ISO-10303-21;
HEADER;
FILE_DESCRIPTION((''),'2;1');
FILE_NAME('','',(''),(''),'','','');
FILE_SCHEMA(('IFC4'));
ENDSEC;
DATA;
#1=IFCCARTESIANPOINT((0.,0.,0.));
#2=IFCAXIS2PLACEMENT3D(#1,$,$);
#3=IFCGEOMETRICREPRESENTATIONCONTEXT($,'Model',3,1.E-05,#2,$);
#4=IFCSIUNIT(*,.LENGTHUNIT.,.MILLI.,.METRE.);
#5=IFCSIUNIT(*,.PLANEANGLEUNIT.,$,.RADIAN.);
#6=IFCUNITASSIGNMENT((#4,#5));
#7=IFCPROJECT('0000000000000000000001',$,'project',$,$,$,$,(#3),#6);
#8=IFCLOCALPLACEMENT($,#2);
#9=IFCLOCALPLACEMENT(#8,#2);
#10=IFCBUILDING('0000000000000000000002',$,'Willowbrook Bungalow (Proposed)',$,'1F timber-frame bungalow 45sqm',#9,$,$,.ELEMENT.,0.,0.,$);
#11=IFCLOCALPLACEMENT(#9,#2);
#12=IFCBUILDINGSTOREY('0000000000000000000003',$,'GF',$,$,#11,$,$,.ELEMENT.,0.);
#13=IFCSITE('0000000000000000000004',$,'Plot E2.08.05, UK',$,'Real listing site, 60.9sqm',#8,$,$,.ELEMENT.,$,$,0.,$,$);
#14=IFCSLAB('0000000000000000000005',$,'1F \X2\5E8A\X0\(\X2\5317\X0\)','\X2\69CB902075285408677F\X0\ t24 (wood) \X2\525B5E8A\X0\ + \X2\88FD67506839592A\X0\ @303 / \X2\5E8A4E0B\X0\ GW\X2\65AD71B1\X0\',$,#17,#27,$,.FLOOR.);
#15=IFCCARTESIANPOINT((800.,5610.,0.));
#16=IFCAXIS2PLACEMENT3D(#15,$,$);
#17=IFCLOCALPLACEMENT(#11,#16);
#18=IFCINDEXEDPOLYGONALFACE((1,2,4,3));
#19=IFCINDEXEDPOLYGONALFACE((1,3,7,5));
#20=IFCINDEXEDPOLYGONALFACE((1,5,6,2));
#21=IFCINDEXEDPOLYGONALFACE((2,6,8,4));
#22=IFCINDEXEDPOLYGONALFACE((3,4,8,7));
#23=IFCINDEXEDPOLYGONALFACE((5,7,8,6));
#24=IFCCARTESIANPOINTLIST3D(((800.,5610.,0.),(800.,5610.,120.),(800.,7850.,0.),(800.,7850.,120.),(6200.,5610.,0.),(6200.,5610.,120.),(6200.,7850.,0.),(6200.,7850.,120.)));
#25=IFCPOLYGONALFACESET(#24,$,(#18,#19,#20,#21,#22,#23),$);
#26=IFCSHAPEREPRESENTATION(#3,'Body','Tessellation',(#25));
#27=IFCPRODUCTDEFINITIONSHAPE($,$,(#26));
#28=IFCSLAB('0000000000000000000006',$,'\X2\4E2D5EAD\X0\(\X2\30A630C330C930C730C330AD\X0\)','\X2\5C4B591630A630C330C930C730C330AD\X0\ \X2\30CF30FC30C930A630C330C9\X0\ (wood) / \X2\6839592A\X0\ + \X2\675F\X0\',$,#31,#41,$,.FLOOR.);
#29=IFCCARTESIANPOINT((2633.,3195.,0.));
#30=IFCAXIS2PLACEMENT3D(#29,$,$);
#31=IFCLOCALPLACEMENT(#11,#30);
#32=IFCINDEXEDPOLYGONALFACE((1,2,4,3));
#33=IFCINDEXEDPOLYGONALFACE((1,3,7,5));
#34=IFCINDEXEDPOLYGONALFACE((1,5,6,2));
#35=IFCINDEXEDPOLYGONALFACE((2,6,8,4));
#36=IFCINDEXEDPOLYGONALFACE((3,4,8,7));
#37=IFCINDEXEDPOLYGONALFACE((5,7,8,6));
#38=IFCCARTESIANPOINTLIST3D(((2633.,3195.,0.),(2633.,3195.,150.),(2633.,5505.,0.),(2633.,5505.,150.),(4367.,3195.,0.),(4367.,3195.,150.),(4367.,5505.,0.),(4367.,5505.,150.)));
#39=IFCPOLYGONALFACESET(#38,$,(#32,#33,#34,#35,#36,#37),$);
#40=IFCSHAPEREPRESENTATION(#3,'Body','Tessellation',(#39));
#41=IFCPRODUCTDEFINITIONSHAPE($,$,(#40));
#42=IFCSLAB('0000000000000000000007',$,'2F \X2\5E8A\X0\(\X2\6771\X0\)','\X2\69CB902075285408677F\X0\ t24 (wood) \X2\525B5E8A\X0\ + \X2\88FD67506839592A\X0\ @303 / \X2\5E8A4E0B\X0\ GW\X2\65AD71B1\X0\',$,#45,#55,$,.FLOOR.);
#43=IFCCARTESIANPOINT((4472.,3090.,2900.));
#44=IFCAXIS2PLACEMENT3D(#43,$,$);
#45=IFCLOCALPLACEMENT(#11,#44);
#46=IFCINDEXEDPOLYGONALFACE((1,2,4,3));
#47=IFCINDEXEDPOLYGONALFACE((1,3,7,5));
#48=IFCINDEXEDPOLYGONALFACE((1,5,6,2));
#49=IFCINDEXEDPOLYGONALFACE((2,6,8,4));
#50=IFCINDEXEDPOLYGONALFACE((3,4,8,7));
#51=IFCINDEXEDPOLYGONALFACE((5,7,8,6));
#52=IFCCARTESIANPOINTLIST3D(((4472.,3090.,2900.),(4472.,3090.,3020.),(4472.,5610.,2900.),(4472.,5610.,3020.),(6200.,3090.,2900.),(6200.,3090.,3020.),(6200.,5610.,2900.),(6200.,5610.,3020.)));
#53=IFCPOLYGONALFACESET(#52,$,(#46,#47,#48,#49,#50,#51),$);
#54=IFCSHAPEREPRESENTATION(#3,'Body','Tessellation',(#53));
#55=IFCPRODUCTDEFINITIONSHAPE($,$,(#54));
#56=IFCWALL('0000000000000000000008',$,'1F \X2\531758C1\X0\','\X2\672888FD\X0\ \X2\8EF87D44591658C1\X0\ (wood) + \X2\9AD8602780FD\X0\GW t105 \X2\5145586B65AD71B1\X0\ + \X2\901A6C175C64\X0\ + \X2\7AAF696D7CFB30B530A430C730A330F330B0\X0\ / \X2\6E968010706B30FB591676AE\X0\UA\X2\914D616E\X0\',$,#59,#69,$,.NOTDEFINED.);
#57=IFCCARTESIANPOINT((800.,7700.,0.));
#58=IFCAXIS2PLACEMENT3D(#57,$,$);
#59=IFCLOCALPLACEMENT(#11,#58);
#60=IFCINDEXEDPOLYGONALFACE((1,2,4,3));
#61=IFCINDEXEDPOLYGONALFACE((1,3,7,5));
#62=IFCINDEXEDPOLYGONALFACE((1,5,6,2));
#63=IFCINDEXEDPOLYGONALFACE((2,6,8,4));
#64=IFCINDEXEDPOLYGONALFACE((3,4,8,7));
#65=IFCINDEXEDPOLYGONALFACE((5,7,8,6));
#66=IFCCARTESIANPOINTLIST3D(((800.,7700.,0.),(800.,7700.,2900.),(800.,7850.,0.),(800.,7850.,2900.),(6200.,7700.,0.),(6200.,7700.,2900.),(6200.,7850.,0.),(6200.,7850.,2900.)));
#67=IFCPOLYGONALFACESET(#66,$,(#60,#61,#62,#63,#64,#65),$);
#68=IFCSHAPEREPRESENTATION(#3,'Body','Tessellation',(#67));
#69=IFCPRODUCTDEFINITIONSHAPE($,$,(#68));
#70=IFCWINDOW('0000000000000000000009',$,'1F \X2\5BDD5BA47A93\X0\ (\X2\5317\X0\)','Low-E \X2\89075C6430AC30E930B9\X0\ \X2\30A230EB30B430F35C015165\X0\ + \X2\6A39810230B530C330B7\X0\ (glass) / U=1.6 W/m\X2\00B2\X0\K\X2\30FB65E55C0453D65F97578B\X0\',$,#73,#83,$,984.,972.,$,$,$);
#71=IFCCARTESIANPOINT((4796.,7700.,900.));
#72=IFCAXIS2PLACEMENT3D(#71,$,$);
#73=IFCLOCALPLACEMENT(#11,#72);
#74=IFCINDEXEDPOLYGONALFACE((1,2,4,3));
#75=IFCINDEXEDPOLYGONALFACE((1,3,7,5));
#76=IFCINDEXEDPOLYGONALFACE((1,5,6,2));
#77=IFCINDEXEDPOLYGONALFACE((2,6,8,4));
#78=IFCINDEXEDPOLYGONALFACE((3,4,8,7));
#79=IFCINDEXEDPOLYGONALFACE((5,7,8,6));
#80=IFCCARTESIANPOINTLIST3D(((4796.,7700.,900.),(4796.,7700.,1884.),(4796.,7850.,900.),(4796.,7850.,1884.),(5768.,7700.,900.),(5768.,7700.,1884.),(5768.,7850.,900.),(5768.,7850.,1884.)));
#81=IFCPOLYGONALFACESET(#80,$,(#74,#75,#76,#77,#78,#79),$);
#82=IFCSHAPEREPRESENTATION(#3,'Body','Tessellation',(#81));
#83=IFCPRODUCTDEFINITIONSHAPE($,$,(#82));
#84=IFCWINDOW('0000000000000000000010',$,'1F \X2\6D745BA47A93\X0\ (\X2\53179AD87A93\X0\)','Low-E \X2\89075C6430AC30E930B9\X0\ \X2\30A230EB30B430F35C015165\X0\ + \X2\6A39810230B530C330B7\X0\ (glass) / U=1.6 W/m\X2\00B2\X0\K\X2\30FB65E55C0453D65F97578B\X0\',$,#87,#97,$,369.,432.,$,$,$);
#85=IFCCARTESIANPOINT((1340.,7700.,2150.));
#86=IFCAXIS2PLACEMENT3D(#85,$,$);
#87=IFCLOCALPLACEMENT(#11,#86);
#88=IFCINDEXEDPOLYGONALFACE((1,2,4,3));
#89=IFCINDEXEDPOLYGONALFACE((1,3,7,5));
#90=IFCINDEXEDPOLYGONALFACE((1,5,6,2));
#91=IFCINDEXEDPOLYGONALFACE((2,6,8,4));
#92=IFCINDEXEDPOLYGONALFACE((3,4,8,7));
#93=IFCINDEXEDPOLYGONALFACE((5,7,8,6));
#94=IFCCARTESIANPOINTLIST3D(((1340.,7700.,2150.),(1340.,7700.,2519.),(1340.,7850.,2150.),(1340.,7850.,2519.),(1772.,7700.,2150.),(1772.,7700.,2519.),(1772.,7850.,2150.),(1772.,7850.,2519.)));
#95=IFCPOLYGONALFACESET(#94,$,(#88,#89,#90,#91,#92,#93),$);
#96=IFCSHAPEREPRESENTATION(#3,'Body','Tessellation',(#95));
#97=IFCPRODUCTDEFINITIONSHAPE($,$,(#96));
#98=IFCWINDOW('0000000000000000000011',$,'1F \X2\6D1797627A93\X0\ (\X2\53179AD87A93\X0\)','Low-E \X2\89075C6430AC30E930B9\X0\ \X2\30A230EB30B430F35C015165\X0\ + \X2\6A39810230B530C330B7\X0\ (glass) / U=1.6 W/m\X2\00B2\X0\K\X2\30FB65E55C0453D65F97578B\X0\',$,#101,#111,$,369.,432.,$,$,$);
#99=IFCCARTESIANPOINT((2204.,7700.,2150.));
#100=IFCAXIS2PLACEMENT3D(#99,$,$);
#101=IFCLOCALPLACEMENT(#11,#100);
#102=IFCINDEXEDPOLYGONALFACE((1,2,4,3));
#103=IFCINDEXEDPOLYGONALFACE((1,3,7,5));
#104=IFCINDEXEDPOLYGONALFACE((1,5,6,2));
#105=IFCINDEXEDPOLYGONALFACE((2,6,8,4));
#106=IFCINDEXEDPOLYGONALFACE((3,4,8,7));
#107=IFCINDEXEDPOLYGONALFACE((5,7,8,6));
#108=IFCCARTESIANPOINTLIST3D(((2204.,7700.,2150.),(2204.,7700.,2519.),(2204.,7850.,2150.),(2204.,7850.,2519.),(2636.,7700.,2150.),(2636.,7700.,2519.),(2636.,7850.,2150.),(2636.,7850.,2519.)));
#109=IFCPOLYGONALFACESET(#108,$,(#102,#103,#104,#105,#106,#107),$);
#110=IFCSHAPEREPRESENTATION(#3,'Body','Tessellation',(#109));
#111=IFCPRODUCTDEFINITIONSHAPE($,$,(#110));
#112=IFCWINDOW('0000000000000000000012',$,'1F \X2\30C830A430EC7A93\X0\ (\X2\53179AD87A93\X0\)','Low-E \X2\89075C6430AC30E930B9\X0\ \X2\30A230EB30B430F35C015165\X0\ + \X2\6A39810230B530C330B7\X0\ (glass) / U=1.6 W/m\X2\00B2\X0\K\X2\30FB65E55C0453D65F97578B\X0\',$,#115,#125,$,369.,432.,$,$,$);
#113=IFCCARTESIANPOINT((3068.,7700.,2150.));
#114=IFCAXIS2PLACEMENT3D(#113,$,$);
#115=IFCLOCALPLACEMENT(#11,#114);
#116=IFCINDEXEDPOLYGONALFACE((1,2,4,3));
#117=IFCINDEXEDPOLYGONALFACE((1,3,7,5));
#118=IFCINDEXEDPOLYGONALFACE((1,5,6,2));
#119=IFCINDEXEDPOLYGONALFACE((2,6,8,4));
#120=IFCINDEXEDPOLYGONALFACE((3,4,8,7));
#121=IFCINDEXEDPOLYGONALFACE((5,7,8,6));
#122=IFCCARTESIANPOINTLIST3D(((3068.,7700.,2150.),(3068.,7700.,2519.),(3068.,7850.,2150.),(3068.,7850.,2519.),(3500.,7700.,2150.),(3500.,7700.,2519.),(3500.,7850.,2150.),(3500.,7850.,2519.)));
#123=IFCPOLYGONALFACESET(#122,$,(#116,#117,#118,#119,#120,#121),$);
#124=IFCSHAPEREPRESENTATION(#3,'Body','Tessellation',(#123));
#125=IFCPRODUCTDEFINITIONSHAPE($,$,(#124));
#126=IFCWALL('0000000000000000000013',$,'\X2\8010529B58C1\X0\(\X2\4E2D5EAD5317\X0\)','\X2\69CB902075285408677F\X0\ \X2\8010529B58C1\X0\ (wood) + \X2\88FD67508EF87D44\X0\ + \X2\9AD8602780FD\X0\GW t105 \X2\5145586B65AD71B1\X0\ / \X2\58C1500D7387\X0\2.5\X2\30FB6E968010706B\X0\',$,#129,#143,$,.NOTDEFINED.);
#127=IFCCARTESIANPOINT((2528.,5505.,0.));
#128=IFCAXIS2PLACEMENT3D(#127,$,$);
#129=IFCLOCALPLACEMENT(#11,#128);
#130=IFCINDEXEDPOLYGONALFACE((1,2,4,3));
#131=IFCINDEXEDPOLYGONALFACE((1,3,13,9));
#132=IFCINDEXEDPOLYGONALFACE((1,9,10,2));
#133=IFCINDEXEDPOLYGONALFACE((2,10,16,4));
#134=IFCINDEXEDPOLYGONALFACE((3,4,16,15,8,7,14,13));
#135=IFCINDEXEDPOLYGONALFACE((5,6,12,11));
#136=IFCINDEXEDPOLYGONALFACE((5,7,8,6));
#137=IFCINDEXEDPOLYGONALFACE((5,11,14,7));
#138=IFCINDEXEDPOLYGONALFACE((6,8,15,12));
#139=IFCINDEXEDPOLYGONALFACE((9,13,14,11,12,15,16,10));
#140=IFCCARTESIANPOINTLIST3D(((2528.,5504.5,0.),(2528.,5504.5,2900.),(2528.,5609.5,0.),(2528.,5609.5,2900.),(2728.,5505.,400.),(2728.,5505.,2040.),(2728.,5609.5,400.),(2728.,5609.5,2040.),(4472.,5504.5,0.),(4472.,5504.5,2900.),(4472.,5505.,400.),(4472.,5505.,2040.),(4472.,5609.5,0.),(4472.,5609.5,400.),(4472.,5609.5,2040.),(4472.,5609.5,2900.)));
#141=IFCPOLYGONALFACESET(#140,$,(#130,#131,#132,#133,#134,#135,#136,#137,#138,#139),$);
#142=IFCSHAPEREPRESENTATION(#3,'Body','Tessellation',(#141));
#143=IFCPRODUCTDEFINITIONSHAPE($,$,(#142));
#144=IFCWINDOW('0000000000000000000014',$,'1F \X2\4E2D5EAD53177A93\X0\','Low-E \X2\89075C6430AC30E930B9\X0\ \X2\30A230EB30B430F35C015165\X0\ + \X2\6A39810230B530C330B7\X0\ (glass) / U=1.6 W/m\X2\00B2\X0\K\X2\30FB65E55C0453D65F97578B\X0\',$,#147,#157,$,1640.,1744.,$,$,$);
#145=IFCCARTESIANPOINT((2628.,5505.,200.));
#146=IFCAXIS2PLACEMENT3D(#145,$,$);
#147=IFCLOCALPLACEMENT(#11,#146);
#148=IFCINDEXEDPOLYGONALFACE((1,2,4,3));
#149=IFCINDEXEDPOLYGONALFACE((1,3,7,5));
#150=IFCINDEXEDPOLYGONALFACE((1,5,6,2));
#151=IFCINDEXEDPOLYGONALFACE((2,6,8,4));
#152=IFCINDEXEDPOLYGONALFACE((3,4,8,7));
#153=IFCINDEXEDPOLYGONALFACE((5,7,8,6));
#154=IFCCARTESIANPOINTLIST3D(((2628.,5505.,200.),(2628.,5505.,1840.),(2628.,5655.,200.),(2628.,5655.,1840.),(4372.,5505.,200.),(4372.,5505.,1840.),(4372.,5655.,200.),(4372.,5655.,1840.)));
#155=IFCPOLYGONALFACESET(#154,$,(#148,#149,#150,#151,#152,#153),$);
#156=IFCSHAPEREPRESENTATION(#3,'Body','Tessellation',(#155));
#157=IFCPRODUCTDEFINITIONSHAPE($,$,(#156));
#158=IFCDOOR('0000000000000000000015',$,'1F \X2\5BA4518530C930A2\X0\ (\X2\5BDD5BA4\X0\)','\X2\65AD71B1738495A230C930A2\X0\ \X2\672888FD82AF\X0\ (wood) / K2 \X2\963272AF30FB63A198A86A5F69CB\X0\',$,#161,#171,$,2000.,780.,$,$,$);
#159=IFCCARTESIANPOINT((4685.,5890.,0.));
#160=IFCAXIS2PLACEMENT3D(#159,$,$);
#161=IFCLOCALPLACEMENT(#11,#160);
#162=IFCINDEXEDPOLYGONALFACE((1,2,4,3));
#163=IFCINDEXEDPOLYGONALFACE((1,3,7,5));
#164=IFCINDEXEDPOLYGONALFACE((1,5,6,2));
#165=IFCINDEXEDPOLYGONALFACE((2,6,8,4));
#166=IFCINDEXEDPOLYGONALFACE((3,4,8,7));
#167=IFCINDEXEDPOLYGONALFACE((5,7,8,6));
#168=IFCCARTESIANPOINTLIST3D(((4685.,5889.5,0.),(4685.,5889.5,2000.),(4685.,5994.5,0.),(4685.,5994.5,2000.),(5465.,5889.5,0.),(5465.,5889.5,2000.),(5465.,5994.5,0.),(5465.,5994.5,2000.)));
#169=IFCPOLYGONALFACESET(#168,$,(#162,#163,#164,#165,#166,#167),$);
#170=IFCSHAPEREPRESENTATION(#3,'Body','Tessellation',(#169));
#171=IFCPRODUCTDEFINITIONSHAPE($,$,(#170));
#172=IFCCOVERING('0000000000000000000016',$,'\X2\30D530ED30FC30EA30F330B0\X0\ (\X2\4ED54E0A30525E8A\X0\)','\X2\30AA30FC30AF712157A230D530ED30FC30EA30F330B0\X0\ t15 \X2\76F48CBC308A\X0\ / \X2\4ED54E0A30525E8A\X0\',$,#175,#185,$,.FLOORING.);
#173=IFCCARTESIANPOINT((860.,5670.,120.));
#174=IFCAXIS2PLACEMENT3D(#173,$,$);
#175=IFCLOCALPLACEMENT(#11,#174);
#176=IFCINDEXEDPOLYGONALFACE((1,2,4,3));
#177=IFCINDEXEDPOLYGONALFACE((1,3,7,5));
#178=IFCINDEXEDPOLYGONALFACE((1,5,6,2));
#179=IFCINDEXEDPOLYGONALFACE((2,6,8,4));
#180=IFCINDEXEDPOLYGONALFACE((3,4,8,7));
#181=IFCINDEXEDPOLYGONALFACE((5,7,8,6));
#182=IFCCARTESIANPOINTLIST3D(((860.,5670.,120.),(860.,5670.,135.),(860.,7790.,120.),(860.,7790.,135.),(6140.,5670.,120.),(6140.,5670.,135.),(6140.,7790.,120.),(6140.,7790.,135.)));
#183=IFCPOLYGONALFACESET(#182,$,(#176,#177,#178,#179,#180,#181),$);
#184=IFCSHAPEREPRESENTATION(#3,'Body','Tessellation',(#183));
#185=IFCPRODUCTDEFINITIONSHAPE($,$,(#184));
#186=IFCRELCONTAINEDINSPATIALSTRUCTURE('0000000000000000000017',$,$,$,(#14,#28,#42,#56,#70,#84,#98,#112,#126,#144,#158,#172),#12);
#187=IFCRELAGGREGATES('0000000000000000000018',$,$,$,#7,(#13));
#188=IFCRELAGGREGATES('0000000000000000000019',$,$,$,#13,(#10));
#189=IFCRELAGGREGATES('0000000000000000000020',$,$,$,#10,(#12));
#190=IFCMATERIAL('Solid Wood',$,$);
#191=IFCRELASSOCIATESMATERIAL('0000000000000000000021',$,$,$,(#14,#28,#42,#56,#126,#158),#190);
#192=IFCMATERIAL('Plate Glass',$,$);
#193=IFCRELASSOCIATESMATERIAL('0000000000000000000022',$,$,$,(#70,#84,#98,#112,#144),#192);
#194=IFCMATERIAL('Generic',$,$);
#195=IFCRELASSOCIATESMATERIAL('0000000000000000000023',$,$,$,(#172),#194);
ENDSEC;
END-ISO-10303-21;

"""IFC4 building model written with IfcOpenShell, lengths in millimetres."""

from ifc_helpers import new_model, si_unit, frame, frame_2d, origin, place, context, project, spatial, rectangle, extrude, material, element, fill, save


model = new_model("IFC4")

# Units and contexts
model_context = context("Model", 3, precision=1e-05, world=origin())
ifc_project = project(units=[si_unit("LENGTHUNIT", "METRE", prefix="MILLI"), si_unit("PLANEANGLEUNIT", "RADIAN")], contexts=[model_context])

# Site, building, storey
site_placement = place(None, origin())
site = spatial("IfcSite", under=ifc_project, at=site_placement, Name="Plot E2.08.05, UK", ObjectType="Real listing site, 60.9sqm", CompositionType="ELEMENT", RefElevation=0.0)
building_placement = place(site_placement, origin())
building = spatial("IfcBuilding", under=site, at=building_placement, Name="Willowbrook Bungalow (Proposed)", ObjectType="1F timber-frame bungalow 45sqm", CompositionType="ELEMENT", ElevationOfRefHeight=0.0, ElevationOfTerrain=0.0)
storey_placement = place(building_placement, origin())
storey = spatial("IfcBuildingStorey", under=building, at=storey_placement, Name="GF", CompositionType="ELEMENT", Elevation=0.0)

# Slabs
ifc_material_1 = material(Name="Solid Wood")
slab_1_placement = place(storey_placement, frame((800.0, 5610.0, 0.0)))
element("IfcSlab", 1, at=slab_1_placement, inside=storey, material=ifc_material_1, Name="1F 床(北)", Description="構造用合板 t24 (wood) 剛床 + 製材根太 @303 / 床下 GW断熱", PredefinedType="FLOOR", context=model_context, shape_type="SweptSolid", body=[
    extrude(rectangle(XDim=5400.0, YDim=2240.0, at=frame_2d((2700.0, 1120.0))), frame((800.0, 5610.0, 0.0)), (0.0, 0.0, 1.0), 120.0),
])
slab_2_placement = place(storey_placement, frame((2633.0, 3195.0, 0.0)))
element("IfcSlab", 2, at=slab_2_placement, inside=storey, material=ifc_material_1, Name="中庭(ウッドデッキ)", Description="屋外ウッドデッキ ハードウッド (wood) / 根太 + 束", PredefinedType="FLOOR", context=model_context, shape_type="SweptSolid", body=[
    extrude(rectangle(XDim=1734.0, YDim=2310.0, at=frame_2d((867.0, 1155.0))), frame((2633.0, 3195.0, 0.0)), (0.0, 0.0, 1.0), 150.0),
])
slab_3_placement = place(storey_placement, frame((4472.0, 3090.0, 2900.0)))
element("IfcSlab", 3, at=slab_3_placement, inside=storey, material=ifc_material_1, Name="2F 床(東)", Description="構造用合板 t24 (wood) 剛床 + 製材根太 @303 / 床下 GW断熱", PredefinedType="FLOOR", context=model_context, shape_type="SweptSolid", body=[
    extrude(rectangle(XDim=1728.0, YDim=2520.0, at=frame_2d((864.0, 1260.0))), frame((4472.0, 3090.0, 2900.0)), (0.0, 0.0, 1.0), 120.0),
])

# Wall, openings, windows
wall_1_placement = place(storey_placement, frame((800.0, 7700.0, 0.0)))
wall_1 = element("IfcWall", 4, at=wall_1_placement, inside=storey, material=ifc_material_1, Name="1F 北壁", Description="木製 軸組外壁 (wood) + 高性能GW t105 充填断熱 + 通気層 + 窯業系サイディング / 準耐火・外皮UA配慮", PredefinedType="NOTDEFINED", context=model_context, shape_type="SweptSolid", body=[
    extrude(rectangle(XDim=5400.0, YDim=150.0, at=frame_2d((2700.0, 75.0))), frame((800.0, 7700.0, 0.0)), (0.0, 0.0, 1.0), 2900.0),
])
opening_1_placement = place(storey_placement, frame((4796.0, 7700.0, 900.0)))
opening_1 = element("IfcOpeningElement", 5, at=opening_1_placement, cuts=wall_1, PredefinedType="NOTDEFINED", context=model_context, shape_type="SweptSolid", body=[
    extrude(rectangle(XDim=972.0, YDim=150.0, at=frame_2d((486.0, 75.0))), frame((4796.0, 7700.0, 900.0)), (0.0, 0.0, 1.0), 984.0),
])
opening_2_placement = place(storey_placement, frame((1340.0, 7700.0, 2150.0)))
opening_2 = element("IfcOpeningElement", 6, at=opening_2_placement, cuts=wall_1, PredefinedType="NOTDEFINED", context=model_context, shape_type="SweptSolid", body=[
    extrude(rectangle(XDim=432.0, YDim=150.0, at=frame_2d((216.0, 75.0))), frame((1340.0, 7700.0, 2150.0)), (0.0, 0.0, 1.0), 369.0),
])
opening_3_placement = place(storey_placement, frame((2204.0, 7700.0, 2150.0)))
opening_3 = element("IfcOpeningElement", 7, at=opening_3_placement, cuts=wall_1, PredefinedType="NOTDEFINED", context=model_context, shape_type="SweptSolid", body=[
    extrude(rectangle(XDim=432.0, YDim=150.0, at=frame_2d((216.0, 75.0))), frame((2204.0, 7700.0, 2150.0)), (0.0, 0.0, 1.0), 369.0),
])
opening_4_placement = place(storey_placement, frame((3068.0, 7700.0, 2150.0)))
opening_4 = element("IfcOpeningElement", 8, at=opening_4_placement, cuts=wall_1, PredefinedType="NOTDEFINED", context=model_context, shape_type="SweptSolid", body=[
    extrude(rectangle(XDim=432.0, YDim=150.0, at=frame_2d((216.0, 75.0))), frame((3068.0, 7700.0, 2150.0)), (0.0, 0.0, 1.0), 369.0),
])
ifc_material_2 = material(Name="Plate Glass")
window_1_placement = place(storey_placement, frame((4796.0, 7700.0, 900.0)))
window_1 = element("IfcWindow", 9, at=window_1_placement, inside=storey, material=ifc_material_2, Name="1F 寝室窓 (北)", Description="Low-E 複層ガラス アルゴン封入 + 樹脂サッシ (glass) / U=1.6 W/m²K・日射取得型", OverallHeight=984.0, OverallWidth=972.0, context=model_context, shape_type="SweptSolid", body=[
    extrude(rectangle(XDim=972.0, YDim=150.0, at=frame_2d((486.0, 75.0))), frame((4796.0, 7700.0, 900.0)), (0.0, 0.0, 1.0), 984.0),
])
fill(opening_1, window_1)
window_2_placement = place(storey_placement, frame((1340.0, 7700.0, 2150.0)))
window_2 = element("IfcWindow", 10, at=window_2_placement, inside=storey, material=ifc_material_2, Name="1F 浴室窓 (北高窓)", Description="Low-E 複層ガラス アルゴン封入 + 樹脂サッシ (glass) / U=1.6 W/m²K・日射取得型", OverallHeight=369.0, OverallWidth=432.0, context=model_context, shape_type="SweptSolid", body=[
    extrude(rectangle(XDim=432.0, YDim=150.0, at=frame_2d((216.0, 75.0))), frame((1340.0, 7700.0, 2150.0)), (0.0, 0.0, 1.0), 369.0),
])
fill(opening_2, window_2)
window_3_placement = place(storey_placement, frame((2204.0, 7700.0, 2150.0)))
window_3 = element("IfcWindow", 11, at=window_3_placement, inside=storey, material=ifc_material_2, Name="1F 洗面窓 (北高窓)", Description="Low-E 複層ガラス アルゴン封入 + 樹脂サッシ (glass) / U=1.6 W/m²K・日射取得型", OverallHeight=369.0, OverallWidth=432.0, context=model_context, shape_type="SweptSolid", body=[
    extrude(rectangle(XDim=432.0, YDim=150.0, at=frame_2d((216.0, 75.0))), frame((2204.0, 7700.0, 2150.0)), (0.0, 0.0, 1.0), 369.0),
])
fill(opening_3, window_3)
window_4_placement = place(storey_placement, frame((3068.0, 7700.0, 2150.0)))
window_4 = element("IfcWindow", 12, at=window_4_placement, inside=storey, material=ifc_material_2, Name="1F トイレ窓 (北高窓)", Description="Low-E 複層ガラス アルゴン封入 + 樹脂サッシ (glass) / U=1.6 W/m²K・日射取得型", OverallHeight=369.0, OverallWidth=432.0, context=model_context, shape_type="SweptSolid", body=[
    extrude(rectangle(XDim=432.0, YDim=150.0, at=frame_2d((216.0, 75.0))), frame((3068.0, 7700.0, 2150.0)), (0.0, 0.0, 1.0), 369.0),
])
fill(opening_4, window_4)

# Wall, opening, window
wall_2_placement = place(storey_placement, frame((2528.0, 5505.0, 0.0)))
wall_2 = element("IfcWall", 13, at=wall_2_placement, inside=storey, material=ifc_material_1, Name="耐力壁(中庭北)", Description="構造用合板 耐力壁 (wood) + 製材軸組 + 高性能GW t105 充填断熱 / 壁倍率2.5・準耐火", PredefinedType="NOTDEFINED", context=model_context, shape_type="SweptSolid", body=[
    extrude(rectangle(XDim=1944.0, YDim=105.0, at=frame_2d((972.0, 52.0))), frame((2528.0, 5505.0, 0.0)), (0.0, 0.0, 1.0), 2900.0),
])
opening_5_placement = place(storey_placement, frame((2628.0, 5505.0, 200.0)))
opening_5 = element("IfcOpeningElement", 14, at=opening_5_placement, cuts=wall_2, PredefinedType="NOTDEFINED", context=model_context, shape_type="SweptSolid", body=[
    extrude(rectangle(XDim=1744.0, YDim=150.0, at=frame_2d((872.0, 75.0))), frame((2628.0, 5505.0, 200.0)), (0.0, 0.0, 1.0), 1640.0),
])
window_5_placement = place(storey_placement, frame((2628.0, 5505.0, 200.0)))
window_5 = element("IfcWindow", 15, at=window_5_placement, inside=storey, material=ifc_material_2, Name="1F 中庭北窓", Description="Low-E 複層ガラス アルゴン封入 + 樹脂サッシ (glass) / U=1.6 W/m²K・日射取得型", OverallHeight=1640.0, OverallWidth=1744.0, context=model_context, shape_type="SweptSolid", body=[
    extrude(rectangle(XDim=1744.0, YDim=150.0, at=frame_2d((872.0, 75.0))), frame((2628.0, 5505.0, 200.0)), (0.0, 0.0, 1.0), 1640.0),
])
fill(opening_5, window_5)

# Door
door_1_placement = place(storey_placement, frame((4685.0, 5890.0, 0.0)))
element("IfcDoor", 16, at=door_1_placement, inside=storey, material=ifc_material_1, Name="1F 室内ドア (寝室)", Description="断熱玄関ドア 木製芯 (wood) / K2 防犯・採風機構", OverallHeight=2000.0, OverallWidth=780.0, context=model_context, shape_type="SweptSolid", body=[
    extrude(rectangle(XDim=780.0, YDim=105.0, at=frame_2d((390.0, 52.0))), frame((4685.0, 5890.0, 0.0)), (0.0, 0.0, 1.0), 2000.0),
])

# Covering
ifc_material_3 = material(Name="Generic")
covering_1_placement = place(storey_placement, frame((860.0, 5670.0, 120.0)))
element("IfcCovering", 17, at=covering_1_placement, inside=storey, material=ifc_material_3, Name="フローリング (仕上げ床)", Description="オーク無垢フローリング t15 直貼り / 仕上げ床", PredefinedType="FLOORING", context=model_context, shape_type="SweptSolid", body=[
    extrude(rectangle(XDim=5280.0, YDim=2120.0, at=frame_2d((2640.0, 1060.0))), frame((860.0, 5670.0, 120.0)), (0.0, 0.0, 1.0), 15.0),
])

save(model, "model.ifc")
